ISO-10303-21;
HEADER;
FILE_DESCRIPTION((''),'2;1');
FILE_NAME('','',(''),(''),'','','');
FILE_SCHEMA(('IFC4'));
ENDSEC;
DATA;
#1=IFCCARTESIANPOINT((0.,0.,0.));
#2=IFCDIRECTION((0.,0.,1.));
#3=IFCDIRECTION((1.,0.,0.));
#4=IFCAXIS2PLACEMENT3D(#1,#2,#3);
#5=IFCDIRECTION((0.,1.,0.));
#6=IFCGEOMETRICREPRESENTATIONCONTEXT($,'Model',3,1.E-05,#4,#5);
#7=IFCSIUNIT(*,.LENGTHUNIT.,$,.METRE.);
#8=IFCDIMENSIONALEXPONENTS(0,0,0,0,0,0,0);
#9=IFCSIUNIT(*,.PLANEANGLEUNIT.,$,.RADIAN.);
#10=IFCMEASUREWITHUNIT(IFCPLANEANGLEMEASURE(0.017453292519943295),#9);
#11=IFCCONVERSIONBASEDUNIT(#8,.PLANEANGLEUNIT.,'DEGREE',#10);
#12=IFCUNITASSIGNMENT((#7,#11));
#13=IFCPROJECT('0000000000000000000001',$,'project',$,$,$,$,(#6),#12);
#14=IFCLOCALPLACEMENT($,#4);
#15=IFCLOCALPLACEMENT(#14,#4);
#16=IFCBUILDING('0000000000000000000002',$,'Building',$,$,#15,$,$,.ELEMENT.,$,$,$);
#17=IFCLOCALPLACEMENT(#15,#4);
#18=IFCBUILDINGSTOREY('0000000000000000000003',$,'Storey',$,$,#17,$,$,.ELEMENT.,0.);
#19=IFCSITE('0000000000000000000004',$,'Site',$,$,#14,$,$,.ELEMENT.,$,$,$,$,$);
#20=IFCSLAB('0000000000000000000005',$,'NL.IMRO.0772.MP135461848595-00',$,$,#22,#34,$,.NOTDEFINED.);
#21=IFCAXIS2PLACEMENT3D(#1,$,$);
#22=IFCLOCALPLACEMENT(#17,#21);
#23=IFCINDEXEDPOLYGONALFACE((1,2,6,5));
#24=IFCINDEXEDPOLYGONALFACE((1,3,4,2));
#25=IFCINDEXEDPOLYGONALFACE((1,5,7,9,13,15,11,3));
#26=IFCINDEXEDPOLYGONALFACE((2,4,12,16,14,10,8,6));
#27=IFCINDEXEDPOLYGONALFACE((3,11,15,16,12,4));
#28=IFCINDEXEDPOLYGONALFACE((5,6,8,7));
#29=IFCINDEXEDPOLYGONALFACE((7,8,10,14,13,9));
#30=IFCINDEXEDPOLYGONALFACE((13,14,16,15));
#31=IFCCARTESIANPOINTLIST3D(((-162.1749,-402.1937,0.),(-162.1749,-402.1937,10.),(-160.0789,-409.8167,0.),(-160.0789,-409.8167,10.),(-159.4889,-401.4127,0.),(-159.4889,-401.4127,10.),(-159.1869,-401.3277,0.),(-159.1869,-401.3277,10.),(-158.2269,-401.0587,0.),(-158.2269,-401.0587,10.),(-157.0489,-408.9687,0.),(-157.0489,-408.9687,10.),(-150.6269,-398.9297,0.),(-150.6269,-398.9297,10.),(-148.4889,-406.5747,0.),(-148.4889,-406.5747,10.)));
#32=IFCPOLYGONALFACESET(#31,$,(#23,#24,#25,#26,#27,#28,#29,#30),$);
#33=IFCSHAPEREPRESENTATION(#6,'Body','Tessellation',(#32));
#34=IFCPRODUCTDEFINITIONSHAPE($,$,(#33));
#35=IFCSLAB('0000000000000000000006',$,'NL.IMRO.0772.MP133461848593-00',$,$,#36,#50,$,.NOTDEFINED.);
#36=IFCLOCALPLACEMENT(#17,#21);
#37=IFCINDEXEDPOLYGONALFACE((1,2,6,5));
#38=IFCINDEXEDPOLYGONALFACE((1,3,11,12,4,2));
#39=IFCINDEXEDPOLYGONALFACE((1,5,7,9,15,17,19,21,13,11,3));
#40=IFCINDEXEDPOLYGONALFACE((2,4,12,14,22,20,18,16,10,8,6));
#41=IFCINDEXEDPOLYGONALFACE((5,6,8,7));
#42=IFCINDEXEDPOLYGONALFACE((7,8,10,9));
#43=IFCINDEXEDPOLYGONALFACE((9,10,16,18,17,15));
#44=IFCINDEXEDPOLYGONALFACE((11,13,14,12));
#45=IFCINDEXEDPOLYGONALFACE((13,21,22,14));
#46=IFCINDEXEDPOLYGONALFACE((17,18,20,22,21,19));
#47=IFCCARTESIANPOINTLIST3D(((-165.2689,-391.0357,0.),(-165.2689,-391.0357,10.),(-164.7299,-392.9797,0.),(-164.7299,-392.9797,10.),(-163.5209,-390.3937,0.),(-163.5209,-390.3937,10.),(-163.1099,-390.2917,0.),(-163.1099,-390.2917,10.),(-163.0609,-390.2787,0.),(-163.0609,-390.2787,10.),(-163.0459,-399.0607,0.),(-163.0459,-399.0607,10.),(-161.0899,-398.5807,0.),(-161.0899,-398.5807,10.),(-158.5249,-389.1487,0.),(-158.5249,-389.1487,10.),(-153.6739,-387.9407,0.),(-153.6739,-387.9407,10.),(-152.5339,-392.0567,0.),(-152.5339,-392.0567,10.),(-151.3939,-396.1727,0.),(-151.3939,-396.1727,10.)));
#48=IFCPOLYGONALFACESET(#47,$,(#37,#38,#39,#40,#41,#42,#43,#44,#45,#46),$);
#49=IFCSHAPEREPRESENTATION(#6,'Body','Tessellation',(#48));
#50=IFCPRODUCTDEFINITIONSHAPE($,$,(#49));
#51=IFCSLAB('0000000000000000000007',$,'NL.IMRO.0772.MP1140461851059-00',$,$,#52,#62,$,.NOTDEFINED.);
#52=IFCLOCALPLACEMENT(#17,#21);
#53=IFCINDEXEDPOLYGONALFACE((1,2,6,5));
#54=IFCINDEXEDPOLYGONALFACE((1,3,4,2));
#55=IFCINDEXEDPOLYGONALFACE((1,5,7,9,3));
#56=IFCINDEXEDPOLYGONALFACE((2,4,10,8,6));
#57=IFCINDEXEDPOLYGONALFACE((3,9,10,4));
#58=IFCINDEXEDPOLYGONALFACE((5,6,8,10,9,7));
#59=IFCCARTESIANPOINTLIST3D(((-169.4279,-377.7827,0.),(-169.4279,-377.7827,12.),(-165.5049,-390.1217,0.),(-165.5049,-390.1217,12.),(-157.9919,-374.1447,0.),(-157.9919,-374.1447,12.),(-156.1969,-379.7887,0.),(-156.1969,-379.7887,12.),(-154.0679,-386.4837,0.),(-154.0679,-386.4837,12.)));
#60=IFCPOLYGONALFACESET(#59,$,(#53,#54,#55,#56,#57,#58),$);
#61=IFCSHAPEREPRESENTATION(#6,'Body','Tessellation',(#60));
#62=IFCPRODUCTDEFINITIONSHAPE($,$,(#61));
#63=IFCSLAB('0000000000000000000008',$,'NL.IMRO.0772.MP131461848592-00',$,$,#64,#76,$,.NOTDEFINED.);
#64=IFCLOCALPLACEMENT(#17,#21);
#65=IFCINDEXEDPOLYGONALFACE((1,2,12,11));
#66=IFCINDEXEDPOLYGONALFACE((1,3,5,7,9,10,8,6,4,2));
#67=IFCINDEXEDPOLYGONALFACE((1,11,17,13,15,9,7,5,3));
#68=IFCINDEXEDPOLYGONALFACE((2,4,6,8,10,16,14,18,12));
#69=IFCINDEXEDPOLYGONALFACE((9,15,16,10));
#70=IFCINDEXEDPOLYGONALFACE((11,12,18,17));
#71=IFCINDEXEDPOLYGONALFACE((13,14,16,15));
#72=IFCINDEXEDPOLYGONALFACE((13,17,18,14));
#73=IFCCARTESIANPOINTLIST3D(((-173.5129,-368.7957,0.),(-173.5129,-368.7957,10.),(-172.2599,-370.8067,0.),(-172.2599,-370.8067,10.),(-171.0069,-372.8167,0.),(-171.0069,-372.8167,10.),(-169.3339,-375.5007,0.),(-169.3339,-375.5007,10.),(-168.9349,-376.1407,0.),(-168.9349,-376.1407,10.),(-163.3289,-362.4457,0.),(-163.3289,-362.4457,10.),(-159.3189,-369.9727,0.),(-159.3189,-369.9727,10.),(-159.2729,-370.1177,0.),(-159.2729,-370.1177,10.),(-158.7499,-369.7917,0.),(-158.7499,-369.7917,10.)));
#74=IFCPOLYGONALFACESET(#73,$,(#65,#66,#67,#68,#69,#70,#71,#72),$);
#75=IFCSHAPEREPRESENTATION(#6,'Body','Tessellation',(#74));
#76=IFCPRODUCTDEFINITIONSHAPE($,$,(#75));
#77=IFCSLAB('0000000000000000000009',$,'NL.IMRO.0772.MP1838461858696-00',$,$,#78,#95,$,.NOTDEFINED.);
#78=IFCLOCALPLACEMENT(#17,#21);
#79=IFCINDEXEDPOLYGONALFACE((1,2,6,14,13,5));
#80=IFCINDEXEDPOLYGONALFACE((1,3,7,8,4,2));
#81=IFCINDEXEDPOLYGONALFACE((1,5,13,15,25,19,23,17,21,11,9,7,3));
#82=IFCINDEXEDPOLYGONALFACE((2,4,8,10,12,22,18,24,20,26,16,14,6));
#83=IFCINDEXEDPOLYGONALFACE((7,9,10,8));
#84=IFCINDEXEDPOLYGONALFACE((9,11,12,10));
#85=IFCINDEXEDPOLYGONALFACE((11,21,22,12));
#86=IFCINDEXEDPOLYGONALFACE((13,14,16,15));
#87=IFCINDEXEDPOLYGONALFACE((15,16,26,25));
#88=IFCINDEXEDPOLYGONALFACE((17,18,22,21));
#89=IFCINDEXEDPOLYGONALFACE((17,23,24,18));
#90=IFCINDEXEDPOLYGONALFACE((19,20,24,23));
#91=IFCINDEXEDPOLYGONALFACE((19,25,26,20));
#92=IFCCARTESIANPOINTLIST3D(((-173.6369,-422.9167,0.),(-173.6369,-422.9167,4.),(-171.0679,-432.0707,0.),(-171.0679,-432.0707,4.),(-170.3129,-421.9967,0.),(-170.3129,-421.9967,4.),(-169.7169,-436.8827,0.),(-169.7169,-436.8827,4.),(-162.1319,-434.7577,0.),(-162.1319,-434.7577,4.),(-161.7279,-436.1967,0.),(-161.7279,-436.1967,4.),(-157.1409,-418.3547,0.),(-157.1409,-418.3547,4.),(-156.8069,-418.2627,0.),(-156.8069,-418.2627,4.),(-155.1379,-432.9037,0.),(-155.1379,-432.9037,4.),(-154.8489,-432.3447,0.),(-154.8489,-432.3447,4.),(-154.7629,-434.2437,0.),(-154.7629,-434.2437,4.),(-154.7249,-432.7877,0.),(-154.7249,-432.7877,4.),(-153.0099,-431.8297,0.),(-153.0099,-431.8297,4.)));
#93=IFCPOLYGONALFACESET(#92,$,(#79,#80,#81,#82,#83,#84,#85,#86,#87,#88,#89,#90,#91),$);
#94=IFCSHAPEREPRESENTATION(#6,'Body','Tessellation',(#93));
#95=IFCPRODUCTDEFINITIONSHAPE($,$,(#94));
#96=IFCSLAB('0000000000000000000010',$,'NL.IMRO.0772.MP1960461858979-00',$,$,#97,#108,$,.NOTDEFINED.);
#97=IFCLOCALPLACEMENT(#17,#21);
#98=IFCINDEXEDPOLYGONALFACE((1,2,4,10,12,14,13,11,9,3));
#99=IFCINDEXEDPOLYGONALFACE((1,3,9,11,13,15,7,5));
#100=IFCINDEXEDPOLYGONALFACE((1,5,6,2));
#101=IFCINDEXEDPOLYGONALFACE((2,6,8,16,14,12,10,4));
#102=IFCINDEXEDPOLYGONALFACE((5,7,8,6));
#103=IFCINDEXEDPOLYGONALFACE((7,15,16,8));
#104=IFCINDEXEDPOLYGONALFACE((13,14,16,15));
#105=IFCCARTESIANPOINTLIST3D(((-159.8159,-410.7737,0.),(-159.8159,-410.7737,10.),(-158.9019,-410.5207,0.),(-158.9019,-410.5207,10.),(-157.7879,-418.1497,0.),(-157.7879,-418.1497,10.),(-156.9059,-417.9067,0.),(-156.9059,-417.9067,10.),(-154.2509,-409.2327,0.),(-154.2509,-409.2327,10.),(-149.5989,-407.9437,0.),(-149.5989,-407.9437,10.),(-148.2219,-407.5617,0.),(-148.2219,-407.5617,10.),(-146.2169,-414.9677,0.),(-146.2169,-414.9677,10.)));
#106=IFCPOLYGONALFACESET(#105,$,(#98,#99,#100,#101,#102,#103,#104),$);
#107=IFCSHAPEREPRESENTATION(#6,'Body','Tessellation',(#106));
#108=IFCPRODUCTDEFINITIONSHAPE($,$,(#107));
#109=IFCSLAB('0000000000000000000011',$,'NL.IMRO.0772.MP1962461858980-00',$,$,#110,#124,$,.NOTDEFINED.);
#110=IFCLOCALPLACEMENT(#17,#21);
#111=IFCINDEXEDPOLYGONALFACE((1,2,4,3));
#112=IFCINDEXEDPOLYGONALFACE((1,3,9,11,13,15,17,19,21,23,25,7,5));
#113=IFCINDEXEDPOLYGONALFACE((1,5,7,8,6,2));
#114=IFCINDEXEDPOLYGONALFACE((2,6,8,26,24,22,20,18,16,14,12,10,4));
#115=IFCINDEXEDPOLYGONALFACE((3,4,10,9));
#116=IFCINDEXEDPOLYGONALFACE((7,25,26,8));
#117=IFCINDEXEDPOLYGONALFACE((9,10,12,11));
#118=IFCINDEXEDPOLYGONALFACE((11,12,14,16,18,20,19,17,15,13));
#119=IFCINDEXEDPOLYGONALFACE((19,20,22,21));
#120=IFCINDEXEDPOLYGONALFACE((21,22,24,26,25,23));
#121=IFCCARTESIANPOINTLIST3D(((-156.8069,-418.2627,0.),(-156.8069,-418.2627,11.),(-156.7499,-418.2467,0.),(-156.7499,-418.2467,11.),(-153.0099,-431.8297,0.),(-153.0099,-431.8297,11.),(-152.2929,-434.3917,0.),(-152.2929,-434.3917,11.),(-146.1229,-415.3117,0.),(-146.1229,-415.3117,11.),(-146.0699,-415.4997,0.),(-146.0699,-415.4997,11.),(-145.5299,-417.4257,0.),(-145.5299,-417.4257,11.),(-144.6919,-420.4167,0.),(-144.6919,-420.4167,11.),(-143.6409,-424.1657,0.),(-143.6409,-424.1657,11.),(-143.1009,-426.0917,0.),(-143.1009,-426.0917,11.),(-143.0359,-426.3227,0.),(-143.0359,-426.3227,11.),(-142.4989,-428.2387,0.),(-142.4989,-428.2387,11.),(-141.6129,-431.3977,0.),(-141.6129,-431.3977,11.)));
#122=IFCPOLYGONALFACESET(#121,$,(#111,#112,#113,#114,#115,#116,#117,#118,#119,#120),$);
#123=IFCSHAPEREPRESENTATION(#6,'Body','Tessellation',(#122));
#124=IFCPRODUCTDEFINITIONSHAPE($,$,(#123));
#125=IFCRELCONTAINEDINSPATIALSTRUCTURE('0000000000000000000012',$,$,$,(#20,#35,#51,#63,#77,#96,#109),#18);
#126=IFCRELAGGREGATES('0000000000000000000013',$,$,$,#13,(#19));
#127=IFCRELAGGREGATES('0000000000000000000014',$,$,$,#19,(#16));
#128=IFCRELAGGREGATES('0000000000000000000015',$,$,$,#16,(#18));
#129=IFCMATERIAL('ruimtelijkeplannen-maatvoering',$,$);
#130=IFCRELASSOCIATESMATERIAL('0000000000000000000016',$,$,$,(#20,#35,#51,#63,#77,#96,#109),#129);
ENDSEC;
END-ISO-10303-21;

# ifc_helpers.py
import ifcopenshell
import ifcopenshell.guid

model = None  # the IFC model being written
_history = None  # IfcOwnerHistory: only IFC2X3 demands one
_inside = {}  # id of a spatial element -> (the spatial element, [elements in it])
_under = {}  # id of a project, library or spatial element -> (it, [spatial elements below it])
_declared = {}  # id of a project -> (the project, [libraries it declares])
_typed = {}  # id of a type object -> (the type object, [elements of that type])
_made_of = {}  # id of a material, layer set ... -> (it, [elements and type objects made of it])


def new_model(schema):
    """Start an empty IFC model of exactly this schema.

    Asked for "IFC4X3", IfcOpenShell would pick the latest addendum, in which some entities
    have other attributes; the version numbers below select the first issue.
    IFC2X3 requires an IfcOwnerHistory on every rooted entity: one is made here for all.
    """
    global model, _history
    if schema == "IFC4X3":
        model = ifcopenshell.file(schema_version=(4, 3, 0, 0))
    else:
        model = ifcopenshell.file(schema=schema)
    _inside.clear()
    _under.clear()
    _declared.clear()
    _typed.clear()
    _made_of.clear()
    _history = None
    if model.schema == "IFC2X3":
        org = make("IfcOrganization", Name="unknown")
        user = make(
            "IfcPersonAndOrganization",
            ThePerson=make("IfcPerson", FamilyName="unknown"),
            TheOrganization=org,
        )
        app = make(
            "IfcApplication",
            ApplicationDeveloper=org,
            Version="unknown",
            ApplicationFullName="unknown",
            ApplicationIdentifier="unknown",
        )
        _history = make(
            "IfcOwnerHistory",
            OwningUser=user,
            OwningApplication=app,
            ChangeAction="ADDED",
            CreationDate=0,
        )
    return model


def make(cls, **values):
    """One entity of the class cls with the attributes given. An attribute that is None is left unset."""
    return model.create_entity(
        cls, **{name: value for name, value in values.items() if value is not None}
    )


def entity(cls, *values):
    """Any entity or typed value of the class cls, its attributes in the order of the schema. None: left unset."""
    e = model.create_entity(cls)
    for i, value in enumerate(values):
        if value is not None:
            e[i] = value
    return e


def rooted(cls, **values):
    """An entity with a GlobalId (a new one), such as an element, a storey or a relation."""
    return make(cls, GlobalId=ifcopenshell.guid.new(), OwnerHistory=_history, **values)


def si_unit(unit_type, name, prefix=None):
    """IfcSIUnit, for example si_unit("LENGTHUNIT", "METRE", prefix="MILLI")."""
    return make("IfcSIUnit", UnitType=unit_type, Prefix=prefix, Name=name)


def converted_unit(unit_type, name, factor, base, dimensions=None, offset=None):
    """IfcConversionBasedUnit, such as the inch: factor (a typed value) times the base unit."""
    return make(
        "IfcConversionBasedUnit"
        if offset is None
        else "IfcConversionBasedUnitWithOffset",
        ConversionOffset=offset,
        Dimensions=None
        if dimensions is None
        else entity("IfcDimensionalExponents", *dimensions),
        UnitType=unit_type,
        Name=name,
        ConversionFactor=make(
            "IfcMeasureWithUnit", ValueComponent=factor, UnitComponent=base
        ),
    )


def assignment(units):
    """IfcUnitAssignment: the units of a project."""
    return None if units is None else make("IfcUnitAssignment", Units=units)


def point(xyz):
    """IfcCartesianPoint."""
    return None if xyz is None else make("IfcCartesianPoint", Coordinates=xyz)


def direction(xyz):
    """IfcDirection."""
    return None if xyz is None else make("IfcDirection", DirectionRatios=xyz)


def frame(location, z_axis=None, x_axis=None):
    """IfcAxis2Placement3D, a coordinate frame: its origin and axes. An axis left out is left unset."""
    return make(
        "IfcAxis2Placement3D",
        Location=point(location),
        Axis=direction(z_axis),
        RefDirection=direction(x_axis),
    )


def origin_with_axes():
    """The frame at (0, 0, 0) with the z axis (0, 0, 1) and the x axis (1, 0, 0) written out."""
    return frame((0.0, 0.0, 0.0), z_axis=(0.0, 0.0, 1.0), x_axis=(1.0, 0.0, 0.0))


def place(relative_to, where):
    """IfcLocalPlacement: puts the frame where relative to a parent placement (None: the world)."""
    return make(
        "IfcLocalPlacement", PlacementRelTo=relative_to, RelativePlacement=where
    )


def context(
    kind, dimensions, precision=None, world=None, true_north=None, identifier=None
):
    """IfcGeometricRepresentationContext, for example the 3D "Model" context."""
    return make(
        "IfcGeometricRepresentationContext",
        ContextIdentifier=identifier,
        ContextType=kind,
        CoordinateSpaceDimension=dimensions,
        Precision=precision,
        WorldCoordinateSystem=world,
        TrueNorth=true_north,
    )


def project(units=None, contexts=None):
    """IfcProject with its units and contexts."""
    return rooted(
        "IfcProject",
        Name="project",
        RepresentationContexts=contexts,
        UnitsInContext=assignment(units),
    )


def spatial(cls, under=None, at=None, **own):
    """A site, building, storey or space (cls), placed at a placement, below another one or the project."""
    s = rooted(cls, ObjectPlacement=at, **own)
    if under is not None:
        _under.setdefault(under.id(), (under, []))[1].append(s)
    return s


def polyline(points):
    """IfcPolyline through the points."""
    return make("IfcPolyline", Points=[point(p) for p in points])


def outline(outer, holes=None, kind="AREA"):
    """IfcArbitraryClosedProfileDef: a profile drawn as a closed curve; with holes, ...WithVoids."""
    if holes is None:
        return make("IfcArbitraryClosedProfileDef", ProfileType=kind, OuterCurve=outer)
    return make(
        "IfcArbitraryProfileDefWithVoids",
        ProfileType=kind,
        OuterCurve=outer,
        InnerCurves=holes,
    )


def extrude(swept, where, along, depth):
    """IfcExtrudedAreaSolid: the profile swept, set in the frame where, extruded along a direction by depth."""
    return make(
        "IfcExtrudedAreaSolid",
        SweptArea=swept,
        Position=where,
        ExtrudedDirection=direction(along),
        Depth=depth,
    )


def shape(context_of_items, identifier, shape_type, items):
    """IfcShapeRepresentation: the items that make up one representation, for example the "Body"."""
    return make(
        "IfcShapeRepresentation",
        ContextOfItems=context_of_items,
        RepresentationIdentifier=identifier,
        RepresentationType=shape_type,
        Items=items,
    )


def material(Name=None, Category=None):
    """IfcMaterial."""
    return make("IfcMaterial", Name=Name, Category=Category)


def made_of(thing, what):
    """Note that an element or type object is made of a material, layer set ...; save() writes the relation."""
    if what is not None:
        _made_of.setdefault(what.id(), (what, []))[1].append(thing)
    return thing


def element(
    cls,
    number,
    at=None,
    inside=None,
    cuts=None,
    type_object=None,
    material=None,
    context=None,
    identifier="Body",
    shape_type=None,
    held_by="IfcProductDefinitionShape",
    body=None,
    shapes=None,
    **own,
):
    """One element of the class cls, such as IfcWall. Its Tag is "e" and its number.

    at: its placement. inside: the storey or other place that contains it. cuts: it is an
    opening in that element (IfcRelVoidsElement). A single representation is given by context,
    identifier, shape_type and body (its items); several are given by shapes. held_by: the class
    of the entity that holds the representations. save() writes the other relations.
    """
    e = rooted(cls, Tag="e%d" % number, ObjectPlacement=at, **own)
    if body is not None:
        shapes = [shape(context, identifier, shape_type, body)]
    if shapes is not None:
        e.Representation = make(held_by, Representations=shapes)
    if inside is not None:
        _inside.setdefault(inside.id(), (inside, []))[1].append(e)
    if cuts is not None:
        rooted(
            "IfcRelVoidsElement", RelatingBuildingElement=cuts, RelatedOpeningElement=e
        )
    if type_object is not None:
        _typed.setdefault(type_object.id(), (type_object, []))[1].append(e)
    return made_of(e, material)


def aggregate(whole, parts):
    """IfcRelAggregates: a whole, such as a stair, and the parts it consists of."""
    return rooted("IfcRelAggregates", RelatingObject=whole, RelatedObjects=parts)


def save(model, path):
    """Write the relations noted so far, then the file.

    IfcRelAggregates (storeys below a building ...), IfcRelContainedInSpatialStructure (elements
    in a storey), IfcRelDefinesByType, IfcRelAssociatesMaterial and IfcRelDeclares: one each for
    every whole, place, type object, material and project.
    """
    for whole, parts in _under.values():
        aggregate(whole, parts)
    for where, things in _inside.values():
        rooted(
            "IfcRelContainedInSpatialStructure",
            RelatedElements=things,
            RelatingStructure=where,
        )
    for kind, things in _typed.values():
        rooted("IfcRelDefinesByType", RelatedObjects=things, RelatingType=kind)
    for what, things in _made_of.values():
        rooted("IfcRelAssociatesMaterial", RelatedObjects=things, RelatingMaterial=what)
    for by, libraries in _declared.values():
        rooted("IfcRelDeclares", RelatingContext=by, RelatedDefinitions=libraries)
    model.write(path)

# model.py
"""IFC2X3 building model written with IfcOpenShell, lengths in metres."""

from ifc_helpers import new_model, entity, si_unit, converted_unit, direction, origin_with_axes, place, context, project, spatial, polyline, outline, extrude, material, element, save


model = new_model("IFC2X3")

# Units and contexts
model_context = context("Model", 3, precision=1e-05, world=origin_with_axes(), true_north=direction((0.0, 1.0, 0.0)))
ifc_project = project(units=[si_unit("LENGTHUNIT", "METRE"), converted_unit("PLANEANGLEUNIT", "DEGREE", entity("IfcPlaneAngleMeasure", 0.017453292519943295), si_unit("PLANEANGLEUNIT", "RADIAN"), dimensions=[0, 0, 0, 0, 0, 0, 0])], contexts=[model_context])

# Site, building, storey
site_placement = place(None, origin_with_axes())
site = spatial("IfcSite", under=ifc_project, at=site_placement, Name="Site", CompositionType="ELEMENT")
building_placement = place(site_placement, origin_with_axes())
building = spatial("IfcBuilding", under=site, at=building_placement, Name="Building", CompositionType="ELEMENT")
storey_placement = place(building_placement, origin_with_axes())
storey = spatial("IfcBuildingStorey", under=building, at=storey_placement, Name="Storey", CompositionType="ELEMENT", Elevation=0.0)

# Slabs
ifc_material_1 = material(Name="ruimtelijkeplannen-maatvoering")
slab_1_placement = place(storey_placement, origin_with_axes())
element("IfcSlab", 1, at=slab_1_placement, inside=storey, material=ifc_material_1, Name="NL.IMRO.0772.MP135461848595-00", PredefinedType="NOTDEFINED", context=model_context, shape_type="SweptSolid", body=[
    extrude(outline(polyline([(-162.1749, -402.1937), (-159.4889, -401.4127), (-159.1869, -401.3277), (-158.2269, -401.0587), (-150.6269, -398.9297), (-148.4889, -406.5747), (-157.0489, -408.9687), (-160.0789, -409.8167), (-162.1749, -402.1937)])), origin_with_axes(), (0.0, 0.0, 1.0), 10.0),
])
slab_2_placement = place(storey_placement, origin_with_axes())
element("IfcSlab", 2, at=slab_2_placement, inside=storey, material=ifc_material_1, Name="NL.IMRO.0772.MP133461848593-00", PredefinedType="NOTDEFINED", context=model_context, shape_type="SweptSolid", body=[
    extrude(outline(polyline([(-151.3939, -396.1727), (-161.0899, -398.5807), (-163.0459, -399.0607), (-164.7299, -392.9797), (-165.2689, -391.0357), (-163.5209, -390.3937), (-163.1099, -390.2917), (-163.0609, -390.2787), (-158.5249, -389.1487), (-153.6739, -387.9407), (-152.5339, -392.0567), (-151.3939, -396.1727)])), origin_with_axes(), (0.0, 0.0, 1.0), 10.0),
])
slab_3_placement = place(storey_placement, origin_with_axes())
element("IfcSlab", 3, at=slab_3_placement, inside=storey, material=ifc_material_1, Name="NL.IMRO.0772.MP1140461851059-00", PredefinedType="NOTDEFINED", context=model_context, shape_type="SweptSolid", body=[
    extrude(outline(polyline([(-157.9919, -374.1447), (-156.1969, -379.7887), (-154.0679, -386.4837), (-165.5049, -390.1217), (-169.4279, -377.7827), (-157.9919, -374.1447)])), origin_with_axes(), (0.0, 0.0, 1.0), 12.0),
])
slab_4_placement = place(storey_placement, origin_with_axes())
element("IfcSlab", 4, at=slab_4_placement, inside=storey, material=ifc_material_1, Name="NL.IMRO.0772.MP131461848592-00", PredefinedType="NOTDEFINED", context=model_context, shape_type="SweptSolid", body=[
    extrude(outline(polyline([(-168.9349, -376.1407), (-169.3339, -375.5007), (-171.0069, -372.8167), (-172.2599, -370.8067), (-173.5129, -368.7957), (-163.3289, -362.4457), (-158.7499, -369.7917), (-159.3189, -369.9727), (-159.2729, -370.1177), (-168.9349, -376.1407)])), origin_with_axes(), (0.0, 0.0, 1.0), 10.0),
])
slab_5_placement = place(storey_placement, origin_with_axes())
element("IfcSlab", 5, at=slab_5_placement, inside=storey, material=ifc_material_1, Name="NL.IMRO.0772.MP1838461858696-00", PredefinedType="NOTDEFINED", context=model_context, shape_type="SweptSolid", body=[
    extrude(outline(polyline([(-156.8069, -418.2627), (-153.0099, -431.8297), (-154.8489, -432.3447), (-154.7249, -432.7877), (-155.1379, -432.9037), (-154.7629, -434.2437), (-161.7279, -436.1967), (-162.1319, -434.7577), (-169.7169, -436.8827), (-171.0679, -432.0707), (-173.6369, -422.9167), (-170.3129, -421.9967), (-157.1409, -418.3547), (-156.8069, -418.2627)])), origin_with_axes(), (0.0, 0.0, 1.0), 4.0),
])
slab_6_placement = place(storey_placement, origin_with_axes())
element("IfcSlab", 6, at=slab_6_placement, inside=storey, material=ifc_material_1, Name="NL.IMRO.0772.MP1960461858979-00", PredefinedType="NOTDEFINED", context=model_context, shape_type="SweptSolid", body=[
    extrude(outline(polyline([(-156.9059, -417.9067), (-157.7879, -418.1497), (-159.8159, -410.7737), (-158.9019, -410.5207), (-154.2509, -409.2327), (-149.5989, -407.9437), (-148.2219, -407.5617), (-146.2169, -414.9677), (-156.9059, -417.9067)])), origin_with_axes(), (0.0, 0.0, 1.0), 10.0),
])
slab_7_placement = place(storey_placement, origin_with_axes())
element("IfcSlab", 7, at=slab_7_placement, inside=storey, material=ifc_material_1, Name="NL.IMRO.0772.MP1962461858980-00", PredefinedType="NOTDEFINED", context=model_context, shape_type="SweptSolid", body=[
    extrude(outline(polyline([(-143.0359, -426.3227), (-142.4989, -428.2387), (-141.6129, -431.3977), (-152.2929, -434.3917), (-153.0099, -431.8297), (-156.8069, -418.2627), (-156.7499, -418.2467), (-146.1229, -415.3117), (-146.0699, -415.4997), (-145.5299, -417.4257), (-144.6919, -420.4167), (-143.6409, -424.1657), (-143.1009, -426.0917), (-143.0359, -426.3227)])), origin_with_axes(), (0.0, 0.0, 1.0), 11.0),
])

save(model, "model.ifc")
